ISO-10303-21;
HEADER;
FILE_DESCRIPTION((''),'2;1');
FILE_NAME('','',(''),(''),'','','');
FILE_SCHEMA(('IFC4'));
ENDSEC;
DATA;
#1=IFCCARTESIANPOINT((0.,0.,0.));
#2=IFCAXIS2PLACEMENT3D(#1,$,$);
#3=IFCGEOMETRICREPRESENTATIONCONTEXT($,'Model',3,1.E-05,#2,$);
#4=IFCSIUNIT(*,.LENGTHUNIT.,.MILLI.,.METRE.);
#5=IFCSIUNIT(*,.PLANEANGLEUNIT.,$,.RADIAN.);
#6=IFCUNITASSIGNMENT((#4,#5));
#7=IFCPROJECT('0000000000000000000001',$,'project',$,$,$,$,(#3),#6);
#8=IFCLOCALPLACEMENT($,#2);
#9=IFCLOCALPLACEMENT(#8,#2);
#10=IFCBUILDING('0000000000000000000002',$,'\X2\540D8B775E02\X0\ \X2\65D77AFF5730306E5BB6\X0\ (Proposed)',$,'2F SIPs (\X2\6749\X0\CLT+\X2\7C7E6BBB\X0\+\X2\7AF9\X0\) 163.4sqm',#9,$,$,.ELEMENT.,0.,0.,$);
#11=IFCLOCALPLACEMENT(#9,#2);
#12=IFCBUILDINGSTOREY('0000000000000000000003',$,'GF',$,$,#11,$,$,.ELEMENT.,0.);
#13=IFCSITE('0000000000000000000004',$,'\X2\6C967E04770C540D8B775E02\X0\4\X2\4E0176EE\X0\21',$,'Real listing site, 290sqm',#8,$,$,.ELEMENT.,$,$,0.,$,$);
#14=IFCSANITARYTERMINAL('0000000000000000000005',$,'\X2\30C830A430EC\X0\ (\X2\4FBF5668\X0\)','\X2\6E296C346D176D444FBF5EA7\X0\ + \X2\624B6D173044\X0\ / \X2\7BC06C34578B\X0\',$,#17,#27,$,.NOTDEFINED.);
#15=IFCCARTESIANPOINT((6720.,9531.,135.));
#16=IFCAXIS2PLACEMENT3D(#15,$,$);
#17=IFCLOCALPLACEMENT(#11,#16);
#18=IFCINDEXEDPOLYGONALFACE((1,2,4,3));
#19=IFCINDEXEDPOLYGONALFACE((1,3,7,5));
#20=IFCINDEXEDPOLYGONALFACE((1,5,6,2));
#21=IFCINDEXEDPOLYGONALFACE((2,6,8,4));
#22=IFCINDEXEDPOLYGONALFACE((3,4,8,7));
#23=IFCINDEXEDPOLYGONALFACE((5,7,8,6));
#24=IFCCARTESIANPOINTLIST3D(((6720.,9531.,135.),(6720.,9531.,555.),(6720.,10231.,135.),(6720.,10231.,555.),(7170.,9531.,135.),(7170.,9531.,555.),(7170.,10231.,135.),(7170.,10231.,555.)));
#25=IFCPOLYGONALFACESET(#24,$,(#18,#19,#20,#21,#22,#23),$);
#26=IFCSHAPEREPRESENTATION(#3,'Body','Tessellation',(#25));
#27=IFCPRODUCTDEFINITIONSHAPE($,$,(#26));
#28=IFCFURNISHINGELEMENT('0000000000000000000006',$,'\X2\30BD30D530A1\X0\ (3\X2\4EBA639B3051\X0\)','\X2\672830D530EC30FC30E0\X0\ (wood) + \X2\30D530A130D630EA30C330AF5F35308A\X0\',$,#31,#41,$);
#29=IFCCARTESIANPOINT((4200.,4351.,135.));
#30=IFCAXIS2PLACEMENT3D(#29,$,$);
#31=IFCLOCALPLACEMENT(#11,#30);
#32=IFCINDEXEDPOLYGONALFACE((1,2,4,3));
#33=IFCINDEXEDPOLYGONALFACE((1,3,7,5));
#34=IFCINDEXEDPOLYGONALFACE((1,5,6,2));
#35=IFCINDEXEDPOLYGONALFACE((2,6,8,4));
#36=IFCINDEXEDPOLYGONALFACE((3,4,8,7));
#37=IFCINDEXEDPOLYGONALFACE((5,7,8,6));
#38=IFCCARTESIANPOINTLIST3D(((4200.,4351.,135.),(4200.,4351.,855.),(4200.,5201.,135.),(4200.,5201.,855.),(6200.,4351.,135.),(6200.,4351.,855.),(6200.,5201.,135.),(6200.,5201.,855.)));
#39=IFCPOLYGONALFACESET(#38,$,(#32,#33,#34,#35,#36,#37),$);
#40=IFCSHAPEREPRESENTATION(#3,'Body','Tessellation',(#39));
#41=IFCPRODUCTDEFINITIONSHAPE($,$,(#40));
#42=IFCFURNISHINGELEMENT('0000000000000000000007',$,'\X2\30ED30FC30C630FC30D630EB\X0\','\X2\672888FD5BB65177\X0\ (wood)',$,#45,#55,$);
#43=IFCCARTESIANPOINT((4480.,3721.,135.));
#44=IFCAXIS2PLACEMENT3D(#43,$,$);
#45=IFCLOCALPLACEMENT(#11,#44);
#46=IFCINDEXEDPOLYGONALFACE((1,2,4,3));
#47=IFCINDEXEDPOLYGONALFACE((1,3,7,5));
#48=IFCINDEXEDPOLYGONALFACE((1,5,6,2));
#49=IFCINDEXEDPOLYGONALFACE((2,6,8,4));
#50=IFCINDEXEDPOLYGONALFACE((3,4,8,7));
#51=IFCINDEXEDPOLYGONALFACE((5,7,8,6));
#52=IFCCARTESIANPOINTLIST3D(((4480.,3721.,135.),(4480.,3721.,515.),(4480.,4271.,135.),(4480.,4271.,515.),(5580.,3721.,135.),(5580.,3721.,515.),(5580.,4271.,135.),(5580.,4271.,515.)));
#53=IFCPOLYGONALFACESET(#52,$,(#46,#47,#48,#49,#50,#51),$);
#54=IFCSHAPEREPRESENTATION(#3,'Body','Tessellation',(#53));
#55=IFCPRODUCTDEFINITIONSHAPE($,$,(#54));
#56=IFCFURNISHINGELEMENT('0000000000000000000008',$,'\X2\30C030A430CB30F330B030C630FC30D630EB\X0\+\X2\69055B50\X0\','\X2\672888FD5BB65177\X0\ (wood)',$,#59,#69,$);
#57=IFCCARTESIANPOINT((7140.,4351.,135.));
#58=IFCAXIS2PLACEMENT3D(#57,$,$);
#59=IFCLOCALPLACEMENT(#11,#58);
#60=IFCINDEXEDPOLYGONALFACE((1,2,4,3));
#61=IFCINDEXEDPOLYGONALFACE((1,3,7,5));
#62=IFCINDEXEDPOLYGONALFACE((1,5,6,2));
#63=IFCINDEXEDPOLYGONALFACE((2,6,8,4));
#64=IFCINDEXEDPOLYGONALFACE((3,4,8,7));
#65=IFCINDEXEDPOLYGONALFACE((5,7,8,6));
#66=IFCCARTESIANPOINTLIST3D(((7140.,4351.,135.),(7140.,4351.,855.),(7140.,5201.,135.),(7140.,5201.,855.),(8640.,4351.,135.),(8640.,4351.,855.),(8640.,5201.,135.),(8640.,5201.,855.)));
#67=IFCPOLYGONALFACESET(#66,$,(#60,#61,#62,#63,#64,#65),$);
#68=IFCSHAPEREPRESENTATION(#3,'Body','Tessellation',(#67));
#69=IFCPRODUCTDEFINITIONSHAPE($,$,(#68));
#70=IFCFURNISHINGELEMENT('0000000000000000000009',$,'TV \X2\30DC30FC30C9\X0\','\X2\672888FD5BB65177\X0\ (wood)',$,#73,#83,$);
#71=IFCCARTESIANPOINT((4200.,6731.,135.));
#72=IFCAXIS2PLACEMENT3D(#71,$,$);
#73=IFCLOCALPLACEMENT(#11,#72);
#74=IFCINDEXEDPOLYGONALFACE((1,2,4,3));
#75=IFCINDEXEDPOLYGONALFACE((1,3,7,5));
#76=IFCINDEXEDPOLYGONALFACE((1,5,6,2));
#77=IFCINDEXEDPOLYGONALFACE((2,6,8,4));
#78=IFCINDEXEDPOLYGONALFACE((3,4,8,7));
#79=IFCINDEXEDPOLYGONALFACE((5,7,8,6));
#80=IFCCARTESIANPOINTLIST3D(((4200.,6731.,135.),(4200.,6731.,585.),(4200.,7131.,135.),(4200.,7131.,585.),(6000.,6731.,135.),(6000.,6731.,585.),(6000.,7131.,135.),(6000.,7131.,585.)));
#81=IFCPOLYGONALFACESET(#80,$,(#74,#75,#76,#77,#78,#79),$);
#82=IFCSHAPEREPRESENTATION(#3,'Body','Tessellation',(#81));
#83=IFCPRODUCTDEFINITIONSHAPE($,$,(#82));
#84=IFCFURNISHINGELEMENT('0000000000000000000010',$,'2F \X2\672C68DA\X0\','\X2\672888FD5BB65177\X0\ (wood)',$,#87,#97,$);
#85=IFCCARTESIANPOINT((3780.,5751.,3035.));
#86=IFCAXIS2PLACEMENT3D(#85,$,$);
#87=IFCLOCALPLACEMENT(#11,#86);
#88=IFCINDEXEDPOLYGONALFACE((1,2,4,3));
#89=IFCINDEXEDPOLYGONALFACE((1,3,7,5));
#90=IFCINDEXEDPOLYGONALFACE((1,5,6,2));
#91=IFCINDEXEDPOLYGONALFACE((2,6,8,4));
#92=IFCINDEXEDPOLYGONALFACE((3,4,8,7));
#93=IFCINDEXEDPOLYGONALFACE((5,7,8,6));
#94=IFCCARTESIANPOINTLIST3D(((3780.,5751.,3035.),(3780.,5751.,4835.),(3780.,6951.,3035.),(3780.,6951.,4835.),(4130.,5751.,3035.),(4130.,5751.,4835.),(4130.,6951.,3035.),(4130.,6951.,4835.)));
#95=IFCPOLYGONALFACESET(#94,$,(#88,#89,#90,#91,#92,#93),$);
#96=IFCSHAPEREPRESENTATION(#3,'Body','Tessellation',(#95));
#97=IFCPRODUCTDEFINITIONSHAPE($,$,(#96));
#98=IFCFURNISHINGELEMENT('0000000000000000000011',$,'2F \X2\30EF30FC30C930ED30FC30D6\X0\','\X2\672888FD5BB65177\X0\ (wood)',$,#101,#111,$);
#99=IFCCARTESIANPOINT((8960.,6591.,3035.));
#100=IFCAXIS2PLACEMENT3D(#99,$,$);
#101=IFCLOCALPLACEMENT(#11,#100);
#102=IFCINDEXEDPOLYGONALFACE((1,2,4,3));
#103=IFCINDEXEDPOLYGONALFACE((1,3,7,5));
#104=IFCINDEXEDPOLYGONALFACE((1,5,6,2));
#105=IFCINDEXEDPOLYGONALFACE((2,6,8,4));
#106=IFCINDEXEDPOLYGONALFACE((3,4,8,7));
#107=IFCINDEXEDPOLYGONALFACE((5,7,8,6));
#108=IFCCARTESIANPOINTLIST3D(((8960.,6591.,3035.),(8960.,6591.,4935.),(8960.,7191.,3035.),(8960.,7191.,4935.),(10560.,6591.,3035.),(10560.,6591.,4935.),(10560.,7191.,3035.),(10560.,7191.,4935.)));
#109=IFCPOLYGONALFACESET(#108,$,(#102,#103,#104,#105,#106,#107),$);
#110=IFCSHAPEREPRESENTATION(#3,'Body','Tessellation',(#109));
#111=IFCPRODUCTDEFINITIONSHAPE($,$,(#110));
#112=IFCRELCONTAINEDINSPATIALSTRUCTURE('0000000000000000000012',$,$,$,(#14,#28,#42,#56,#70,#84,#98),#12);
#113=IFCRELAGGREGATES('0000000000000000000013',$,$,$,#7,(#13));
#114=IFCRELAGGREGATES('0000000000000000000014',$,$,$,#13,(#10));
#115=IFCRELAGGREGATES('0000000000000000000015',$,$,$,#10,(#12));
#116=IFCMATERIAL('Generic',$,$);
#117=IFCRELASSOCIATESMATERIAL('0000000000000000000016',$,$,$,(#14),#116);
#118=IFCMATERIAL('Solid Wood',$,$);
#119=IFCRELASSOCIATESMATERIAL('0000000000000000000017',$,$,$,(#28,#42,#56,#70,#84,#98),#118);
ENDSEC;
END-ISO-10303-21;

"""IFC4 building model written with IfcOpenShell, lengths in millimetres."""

from ifc_helpers import new_model, si_unit, frame, frame_2d, origin, place, context, project, spatial, rectangle, extrude, material, element, save


model = new_model("IFC4")

# Units and contexts
model_context = context("Model", 3, precision=1e-05, world=origin())
ifc_project = project(units=[si_unit("LENGTHUNIT", "METRE", prefix="MILLI"), si_unit("PLANEANGLEUNIT", "RADIAN")], contexts=[model_context])

# Site, building, storey
site_placement = place(None, origin())
site = spatial("IfcSite", under=ifc_project, at=site_placement, Name="沖縄県名護市4丁目21", ObjectType="Real listing site, 290sqm", CompositionType="ELEMENT", RefElevation=0.0)
building_placement = place(site_placement, origin())
building = spatial("IfcBuilding", under=site, at=building_placement, Name="名護市 旗竿地の家 (Proposed)", ObjectType="2F SIPs (杉CLT+籾殻+竹) 163.4sqm", CompositionType="ELEMENT", ElevationOfRefHeight=0.0, ElevationOfTerrain=0.0)
storey_placement = place(building_placement, origin())
storey = spatial("IfcBuildingStorey", under=building, at=storey_placement, Name="GF", CompositionType="ELEMENT", Elevation=0.0)

# Shared definitions
ifc_material_1 = material(Name="Generic")

# Shared definitions
ifc_material_2 = material(Name="Solid Wood")

# Sanitary terminal
sanitary_terminal_1_placement = place(storey_placement, frame((6720.0, 9531.0, 135.0)))
element("IfcSanitaryTerminal", 1, at=sanitary_terminal_1_placement, inside=storey, material=ifc_material_1, Name="トイレ (便器)", Description="温水洗浄便座 + 手洗い / 節水型", PredefinedType="NOTDEFINED", context=model_context, shape_type="SweptSolid", body=[
    extrude(rectangle(XDim=450.0, YDim=700.0, at=frame_2d((225.0, 350.0))), frame((6720.0, 9531.0, 135.0)), (0.0, 0.0, 1.0), 420.0),
])

# Furnishing elements
furnishing_1_placement = place(storey_placement, frame((4200.0, 4351.0, 135.0)))
element("IfcFurnishingElement", 2, at=furnishing_1_placement, inside=storey, material=ifc_material_2, Name="ソファ (3人掛け)", Description="木フレーム (wood) + ファブリック張り", context=model_context, shape_type="SweptSolid", body=[
    extrude(rectangle(XDim=2000.0, YDim=850.0, at=frame_2d((1000.0, 425.0))), frame((4200.0, 4351.0, 135.0)), (0.0, 0.0, 1.0), 720.0),
])
furnishing_2_placement = place(storey_placement, frame((4480.0, 3721.0, 135.0)))
element("IfcFurnishingElement", 3, at=furnishing_2_placement, inside=storey, material=ifc_material_2, Name="ローテーブル", Description="木製家具 (wood)", context=model_context, shape_type="SweptSolid", body=[
    extrude(rectangle(XDim=1100.0, YDim=550.0, at=frame_2d((550.0, 275.0))), frame((4480.0, 3721.0, 135.0)), (0.0, 0.0, 1.0), 380.0),
])
furnishing_3_placement = place(storey_placement, frame((7140.0, 4351.0, 135.0)))
element("IfcFurnishingElement", 4, at=furnishing_3_placement, inside=storey, material=ifc_material_2, Name="ダイニングテーブル+椅子", Description="木製家具 (wood)", context=model_context, shape_type="SweptSolid", body=[
    extrude(rectangle(XDim=1500.0, YDim=850.0, at=frame_2d((750.0, 425.0))), frame((7140.0, 4351.0, 135.0)), (0.0, 0.0, 1.0), 720.0),
])
furnishing_4_placement = place(storey_placement, frame((4200.0, 6731.0, 135.0)))
element("IfcFurnishingElement", 5, at=furnishing_4_placement, inside=storey, material=ifc_material_2, Name="TV ボード", Description="木製家具 (wood)", context=model_context, shape_type="SweptSolid", body=[
    extrude(rectangle(XDim=1800.0, YDim=400.0, at=frame_2d((900.0, 200.0))), frame((4200.0, 6731.0, 135.0)), (0.0, 0.0, 1.0), 450.0),
])
furnishing_5_placement = place(storey_placement, frame((3780.0, 5751.0, 3035.0)))
element("IfcFurnishingElement", 6, at=furnishing_5_placement, inside=storey, material=ifc_material_2, Name="2F 本棚", Description="木製家具 (wood)", context=model_context, shape_type="SweptSolid", body=[
    extrude(rectangle(XDim=350.0, YDim=1200.0, at=frame_2d((175.0, 600.0))), frame((3780.0, 5751.0, 3035.0)), (0.0, 0.0, 1.0), 1800.0),
])
furnishing_6_placement = place(storey_placement, frame((8960.0, 6591.0, 3035.0)))
element("IfcFurnishingElement", 7, at=furnishing_6_placement, inside=storey, material=ifc_material_2, Name="2F ワードローブ", Description="木製家具 (wood)", context=model_context, shape_type="SweptSolid", body=[
    extrude(rectangle(XDim=1600.0, YDim=600.0, at=frame_2d((800.0, 300.0))), frame((8960.0, 6591.0, 3035.0)), (0.0, 0.0, 1.0), 1900.0),
])

save(model, "model.ifc")
